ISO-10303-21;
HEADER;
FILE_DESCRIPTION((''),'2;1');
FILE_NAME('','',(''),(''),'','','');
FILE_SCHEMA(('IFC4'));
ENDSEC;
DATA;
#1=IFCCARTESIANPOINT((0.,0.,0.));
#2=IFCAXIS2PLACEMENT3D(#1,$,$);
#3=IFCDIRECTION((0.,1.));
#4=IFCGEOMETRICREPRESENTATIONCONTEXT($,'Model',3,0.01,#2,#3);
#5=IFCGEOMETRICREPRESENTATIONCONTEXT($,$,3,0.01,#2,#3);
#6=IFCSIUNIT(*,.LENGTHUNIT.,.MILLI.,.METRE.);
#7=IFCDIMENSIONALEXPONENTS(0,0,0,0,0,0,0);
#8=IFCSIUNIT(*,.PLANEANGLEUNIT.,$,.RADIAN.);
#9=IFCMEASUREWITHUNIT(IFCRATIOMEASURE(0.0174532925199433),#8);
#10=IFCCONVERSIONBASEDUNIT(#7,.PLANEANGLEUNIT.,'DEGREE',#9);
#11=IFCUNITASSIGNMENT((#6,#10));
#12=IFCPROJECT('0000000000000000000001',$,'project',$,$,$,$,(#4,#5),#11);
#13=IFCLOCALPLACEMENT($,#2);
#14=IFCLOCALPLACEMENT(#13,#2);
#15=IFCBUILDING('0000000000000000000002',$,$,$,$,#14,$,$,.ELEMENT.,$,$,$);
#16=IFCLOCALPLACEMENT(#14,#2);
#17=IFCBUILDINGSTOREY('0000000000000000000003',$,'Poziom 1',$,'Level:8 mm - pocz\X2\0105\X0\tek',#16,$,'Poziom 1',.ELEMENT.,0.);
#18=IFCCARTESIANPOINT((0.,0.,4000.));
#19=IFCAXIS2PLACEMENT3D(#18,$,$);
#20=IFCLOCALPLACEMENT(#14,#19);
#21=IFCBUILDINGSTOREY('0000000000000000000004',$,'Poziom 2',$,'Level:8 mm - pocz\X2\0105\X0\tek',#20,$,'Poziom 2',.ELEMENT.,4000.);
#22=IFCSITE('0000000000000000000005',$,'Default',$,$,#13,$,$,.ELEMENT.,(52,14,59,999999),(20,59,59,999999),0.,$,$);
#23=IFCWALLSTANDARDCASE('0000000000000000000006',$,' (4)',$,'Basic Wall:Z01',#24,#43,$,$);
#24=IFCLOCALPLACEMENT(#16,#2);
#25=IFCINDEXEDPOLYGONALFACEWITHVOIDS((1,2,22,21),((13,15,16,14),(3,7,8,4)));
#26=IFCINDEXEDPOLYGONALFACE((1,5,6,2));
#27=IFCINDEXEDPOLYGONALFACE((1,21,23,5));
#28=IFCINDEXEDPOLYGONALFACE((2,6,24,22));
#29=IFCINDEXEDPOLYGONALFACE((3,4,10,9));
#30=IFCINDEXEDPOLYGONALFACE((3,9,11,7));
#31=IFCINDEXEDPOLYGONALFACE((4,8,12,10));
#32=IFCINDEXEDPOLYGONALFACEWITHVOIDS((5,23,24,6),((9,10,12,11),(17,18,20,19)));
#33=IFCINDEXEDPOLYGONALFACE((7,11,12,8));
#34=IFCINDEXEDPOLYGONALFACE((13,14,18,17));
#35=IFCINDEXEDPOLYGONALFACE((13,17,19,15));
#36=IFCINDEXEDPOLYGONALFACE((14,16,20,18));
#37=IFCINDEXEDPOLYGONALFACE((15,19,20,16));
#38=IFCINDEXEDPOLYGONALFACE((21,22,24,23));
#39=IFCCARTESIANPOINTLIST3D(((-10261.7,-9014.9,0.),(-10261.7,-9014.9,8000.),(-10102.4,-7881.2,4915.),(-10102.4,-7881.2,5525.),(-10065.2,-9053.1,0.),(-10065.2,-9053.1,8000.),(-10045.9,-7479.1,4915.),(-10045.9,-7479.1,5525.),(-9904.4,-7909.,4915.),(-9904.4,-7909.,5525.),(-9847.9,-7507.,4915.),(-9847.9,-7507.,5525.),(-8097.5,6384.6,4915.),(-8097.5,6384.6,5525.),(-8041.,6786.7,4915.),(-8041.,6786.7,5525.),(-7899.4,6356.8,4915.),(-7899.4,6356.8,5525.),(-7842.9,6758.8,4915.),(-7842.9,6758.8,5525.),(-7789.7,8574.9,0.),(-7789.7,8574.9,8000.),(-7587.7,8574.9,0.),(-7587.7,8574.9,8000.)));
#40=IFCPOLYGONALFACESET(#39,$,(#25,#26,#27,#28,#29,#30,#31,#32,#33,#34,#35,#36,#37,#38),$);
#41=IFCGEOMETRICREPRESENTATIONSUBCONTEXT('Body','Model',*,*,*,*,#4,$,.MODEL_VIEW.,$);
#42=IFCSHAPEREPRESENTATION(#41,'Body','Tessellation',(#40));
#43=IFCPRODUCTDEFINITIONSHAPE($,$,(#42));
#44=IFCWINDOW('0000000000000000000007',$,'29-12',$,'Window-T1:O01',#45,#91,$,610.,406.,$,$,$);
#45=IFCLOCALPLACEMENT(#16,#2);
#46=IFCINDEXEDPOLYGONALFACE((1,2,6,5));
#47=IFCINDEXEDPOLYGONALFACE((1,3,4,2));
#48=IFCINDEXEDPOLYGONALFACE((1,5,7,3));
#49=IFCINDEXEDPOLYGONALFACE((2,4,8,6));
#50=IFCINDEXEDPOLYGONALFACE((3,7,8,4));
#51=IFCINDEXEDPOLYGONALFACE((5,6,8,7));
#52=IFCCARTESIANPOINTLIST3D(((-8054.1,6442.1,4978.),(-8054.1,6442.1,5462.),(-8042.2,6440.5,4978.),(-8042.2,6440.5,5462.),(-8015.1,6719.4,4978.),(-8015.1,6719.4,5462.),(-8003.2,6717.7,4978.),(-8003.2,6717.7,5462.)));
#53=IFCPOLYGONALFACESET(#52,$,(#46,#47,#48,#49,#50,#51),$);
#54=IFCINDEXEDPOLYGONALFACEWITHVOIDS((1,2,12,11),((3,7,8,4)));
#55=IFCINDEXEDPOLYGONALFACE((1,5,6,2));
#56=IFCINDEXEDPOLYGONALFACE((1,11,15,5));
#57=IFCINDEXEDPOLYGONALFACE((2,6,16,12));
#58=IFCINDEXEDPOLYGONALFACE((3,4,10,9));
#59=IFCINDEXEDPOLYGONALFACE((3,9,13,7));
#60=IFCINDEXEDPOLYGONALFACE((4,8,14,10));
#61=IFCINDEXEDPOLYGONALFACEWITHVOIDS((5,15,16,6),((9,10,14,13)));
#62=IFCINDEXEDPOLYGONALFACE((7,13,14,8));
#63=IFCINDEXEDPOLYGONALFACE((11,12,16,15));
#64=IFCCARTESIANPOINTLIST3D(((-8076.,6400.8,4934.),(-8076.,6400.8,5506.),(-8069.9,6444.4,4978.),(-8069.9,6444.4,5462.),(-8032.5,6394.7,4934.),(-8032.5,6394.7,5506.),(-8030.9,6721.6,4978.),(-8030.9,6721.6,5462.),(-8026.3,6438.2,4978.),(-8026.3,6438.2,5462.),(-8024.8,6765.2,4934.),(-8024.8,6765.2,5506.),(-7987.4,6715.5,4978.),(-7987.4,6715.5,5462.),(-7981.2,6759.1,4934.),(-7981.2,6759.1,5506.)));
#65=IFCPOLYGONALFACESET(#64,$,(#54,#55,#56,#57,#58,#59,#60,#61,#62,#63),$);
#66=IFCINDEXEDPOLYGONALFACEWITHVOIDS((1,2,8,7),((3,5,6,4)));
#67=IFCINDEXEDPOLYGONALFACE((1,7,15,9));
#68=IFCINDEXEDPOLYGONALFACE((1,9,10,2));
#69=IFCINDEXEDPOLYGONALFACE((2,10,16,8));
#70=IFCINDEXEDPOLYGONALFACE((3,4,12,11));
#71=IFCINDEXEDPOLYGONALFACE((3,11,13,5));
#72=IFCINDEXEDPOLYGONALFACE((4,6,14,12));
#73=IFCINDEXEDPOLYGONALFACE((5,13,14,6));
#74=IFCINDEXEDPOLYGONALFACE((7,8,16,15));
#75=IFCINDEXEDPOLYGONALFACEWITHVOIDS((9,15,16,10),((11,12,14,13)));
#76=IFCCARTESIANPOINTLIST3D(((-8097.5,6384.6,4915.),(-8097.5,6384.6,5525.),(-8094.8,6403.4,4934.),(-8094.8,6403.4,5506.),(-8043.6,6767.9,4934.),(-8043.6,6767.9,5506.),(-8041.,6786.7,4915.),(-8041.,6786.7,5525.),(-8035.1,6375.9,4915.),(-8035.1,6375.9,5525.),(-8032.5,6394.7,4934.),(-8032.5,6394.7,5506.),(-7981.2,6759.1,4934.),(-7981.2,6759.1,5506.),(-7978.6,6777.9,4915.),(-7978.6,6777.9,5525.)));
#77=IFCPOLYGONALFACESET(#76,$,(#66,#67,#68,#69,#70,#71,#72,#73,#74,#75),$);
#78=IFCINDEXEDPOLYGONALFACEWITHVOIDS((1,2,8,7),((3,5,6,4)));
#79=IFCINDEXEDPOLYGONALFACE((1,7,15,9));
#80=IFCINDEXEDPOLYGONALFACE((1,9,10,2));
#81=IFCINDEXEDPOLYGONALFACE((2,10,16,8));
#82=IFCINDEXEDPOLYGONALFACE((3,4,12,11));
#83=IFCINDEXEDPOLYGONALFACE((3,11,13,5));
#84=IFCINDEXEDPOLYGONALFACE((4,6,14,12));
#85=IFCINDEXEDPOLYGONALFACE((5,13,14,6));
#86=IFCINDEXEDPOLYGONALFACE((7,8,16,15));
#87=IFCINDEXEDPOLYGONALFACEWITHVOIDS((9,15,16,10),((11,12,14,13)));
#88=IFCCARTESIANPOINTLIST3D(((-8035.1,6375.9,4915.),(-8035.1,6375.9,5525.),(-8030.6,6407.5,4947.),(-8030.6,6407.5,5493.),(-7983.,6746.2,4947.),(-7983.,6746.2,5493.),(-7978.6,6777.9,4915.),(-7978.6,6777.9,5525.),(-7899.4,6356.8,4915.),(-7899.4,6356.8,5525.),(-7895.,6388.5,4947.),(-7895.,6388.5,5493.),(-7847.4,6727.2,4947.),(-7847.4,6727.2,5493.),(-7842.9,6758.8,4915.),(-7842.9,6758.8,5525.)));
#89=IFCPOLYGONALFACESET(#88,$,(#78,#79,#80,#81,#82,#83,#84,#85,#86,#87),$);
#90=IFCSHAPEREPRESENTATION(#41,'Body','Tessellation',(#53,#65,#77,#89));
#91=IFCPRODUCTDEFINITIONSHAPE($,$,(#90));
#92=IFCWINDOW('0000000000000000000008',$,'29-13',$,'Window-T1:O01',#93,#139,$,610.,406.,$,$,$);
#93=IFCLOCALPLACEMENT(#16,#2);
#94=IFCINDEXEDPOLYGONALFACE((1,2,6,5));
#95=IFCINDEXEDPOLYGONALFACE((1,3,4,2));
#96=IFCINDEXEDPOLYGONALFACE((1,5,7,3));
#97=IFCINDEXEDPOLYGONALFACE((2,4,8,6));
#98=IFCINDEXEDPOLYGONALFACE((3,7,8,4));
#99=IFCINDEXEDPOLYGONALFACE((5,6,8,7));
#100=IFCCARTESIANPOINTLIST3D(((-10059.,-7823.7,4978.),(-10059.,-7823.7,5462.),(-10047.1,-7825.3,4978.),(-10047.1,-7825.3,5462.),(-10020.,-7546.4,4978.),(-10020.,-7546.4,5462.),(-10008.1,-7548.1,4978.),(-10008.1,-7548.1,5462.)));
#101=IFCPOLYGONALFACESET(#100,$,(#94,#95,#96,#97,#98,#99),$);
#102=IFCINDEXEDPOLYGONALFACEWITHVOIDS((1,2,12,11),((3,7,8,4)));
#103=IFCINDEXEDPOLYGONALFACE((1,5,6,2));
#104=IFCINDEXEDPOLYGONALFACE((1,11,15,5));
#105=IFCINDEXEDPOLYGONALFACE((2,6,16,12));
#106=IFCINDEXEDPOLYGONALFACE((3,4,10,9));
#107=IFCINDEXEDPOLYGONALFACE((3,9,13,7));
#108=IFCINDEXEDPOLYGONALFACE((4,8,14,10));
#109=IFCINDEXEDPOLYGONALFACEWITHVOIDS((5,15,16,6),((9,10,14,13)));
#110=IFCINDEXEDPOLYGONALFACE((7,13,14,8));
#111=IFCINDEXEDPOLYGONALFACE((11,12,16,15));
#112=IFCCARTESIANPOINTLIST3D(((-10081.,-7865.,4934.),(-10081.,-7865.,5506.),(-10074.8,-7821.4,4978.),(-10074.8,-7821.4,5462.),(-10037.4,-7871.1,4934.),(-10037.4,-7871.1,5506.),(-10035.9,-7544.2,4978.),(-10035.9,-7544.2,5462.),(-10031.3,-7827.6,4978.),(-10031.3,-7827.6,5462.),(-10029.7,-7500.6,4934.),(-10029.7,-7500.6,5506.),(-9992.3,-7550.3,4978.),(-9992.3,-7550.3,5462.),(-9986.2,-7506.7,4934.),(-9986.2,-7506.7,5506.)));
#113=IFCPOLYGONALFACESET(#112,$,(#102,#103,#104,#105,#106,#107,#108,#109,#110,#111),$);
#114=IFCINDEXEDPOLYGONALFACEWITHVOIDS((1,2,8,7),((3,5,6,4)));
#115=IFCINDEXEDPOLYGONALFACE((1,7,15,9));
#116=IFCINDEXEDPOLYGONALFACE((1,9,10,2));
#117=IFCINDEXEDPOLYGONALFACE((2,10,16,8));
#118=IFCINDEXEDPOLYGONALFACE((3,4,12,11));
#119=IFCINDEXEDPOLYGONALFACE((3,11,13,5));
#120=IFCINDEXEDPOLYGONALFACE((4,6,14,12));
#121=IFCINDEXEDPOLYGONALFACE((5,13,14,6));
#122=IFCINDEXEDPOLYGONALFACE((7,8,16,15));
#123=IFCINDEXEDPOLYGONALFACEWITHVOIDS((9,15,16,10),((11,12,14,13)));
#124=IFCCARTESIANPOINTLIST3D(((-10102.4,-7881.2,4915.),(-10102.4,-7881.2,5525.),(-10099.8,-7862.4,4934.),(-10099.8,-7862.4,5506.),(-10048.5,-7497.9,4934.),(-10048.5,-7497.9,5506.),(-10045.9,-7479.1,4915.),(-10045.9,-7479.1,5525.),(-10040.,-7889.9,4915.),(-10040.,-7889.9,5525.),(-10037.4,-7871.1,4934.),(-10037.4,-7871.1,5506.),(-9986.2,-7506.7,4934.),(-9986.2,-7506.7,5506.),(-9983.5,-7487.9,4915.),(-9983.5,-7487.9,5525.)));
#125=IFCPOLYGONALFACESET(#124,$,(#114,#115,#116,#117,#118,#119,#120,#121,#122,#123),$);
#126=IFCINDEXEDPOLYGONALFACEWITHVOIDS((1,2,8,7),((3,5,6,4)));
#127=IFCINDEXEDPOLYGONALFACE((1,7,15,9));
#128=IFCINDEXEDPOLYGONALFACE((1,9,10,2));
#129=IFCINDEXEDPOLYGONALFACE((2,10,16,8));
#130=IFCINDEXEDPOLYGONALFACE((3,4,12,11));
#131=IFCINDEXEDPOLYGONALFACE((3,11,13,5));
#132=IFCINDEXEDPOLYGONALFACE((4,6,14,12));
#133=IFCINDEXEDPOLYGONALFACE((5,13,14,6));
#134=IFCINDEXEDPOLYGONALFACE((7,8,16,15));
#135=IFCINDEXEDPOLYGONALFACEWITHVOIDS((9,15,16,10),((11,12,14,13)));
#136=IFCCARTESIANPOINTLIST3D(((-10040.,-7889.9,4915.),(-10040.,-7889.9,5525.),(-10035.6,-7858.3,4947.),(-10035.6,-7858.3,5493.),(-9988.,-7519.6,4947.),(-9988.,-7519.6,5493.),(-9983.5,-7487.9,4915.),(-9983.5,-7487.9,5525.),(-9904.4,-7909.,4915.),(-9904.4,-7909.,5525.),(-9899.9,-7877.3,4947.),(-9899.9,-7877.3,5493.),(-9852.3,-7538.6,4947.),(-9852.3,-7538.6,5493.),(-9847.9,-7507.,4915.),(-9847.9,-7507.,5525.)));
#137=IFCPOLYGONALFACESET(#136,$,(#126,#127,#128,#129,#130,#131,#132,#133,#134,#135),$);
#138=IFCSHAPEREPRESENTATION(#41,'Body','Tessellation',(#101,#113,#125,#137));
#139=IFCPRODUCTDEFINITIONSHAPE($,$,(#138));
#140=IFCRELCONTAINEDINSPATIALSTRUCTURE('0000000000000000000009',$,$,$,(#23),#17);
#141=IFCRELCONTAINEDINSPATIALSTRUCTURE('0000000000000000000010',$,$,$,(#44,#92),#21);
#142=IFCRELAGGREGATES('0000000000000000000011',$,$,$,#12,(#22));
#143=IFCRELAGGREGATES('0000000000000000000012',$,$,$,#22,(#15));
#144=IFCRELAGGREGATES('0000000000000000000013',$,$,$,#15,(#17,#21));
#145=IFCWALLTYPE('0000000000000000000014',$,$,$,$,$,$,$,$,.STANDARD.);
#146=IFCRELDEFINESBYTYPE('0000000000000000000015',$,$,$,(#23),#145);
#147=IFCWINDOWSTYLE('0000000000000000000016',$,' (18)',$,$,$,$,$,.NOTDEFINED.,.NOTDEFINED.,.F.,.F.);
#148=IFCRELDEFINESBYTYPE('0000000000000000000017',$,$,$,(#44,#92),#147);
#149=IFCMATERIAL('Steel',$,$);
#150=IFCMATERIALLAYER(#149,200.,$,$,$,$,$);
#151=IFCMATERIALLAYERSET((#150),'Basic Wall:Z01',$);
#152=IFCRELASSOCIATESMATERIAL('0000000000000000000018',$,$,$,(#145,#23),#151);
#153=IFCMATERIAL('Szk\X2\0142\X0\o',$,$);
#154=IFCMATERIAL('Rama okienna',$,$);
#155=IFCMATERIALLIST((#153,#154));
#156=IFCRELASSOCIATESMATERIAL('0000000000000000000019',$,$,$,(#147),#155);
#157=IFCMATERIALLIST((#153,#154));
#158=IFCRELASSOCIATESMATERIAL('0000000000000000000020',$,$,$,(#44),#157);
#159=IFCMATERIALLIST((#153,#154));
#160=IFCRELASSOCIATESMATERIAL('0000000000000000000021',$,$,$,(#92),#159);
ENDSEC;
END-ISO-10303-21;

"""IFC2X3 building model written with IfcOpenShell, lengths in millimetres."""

from ifc_helpers import new_model, entity, si_unit, converted_unit, direction, frame, frame_2d, origin, place, context, subcontext, project, spatial, polyline, rectangle, outline, extrude, source, transform, mapped, material, material_list, layer, layer_set, layer_usage, type_object, type_shapes, element, fill, save


model = new_model("IFC2X3")

# Units and contexts
model_context = context("Model", 3, precision=0.01, world=origin(), true_north=direction((0.0, 1.0)))
context_of_model = context(None, 3, precision=0.01, world=origin(), true_north=direction((0.0, 1.0)))
body_context = subcontext(model_context, "Body", "Model", "MODEL_VIEW")
ifc_project = project(units=[si_unit("LENGTHUNIT", "METRE", prefix="MILLI"), converted_unit("PLANEANGLEUNIT", "DEGREE", entity("IfcRatioMeasure", 0.0174532925199433), si_unit("PLANEANGLEUNIT", "RADIAN"), dimensions=[0, 0, 0, 0, 0, 0, 0])], contexts=[model_context, context_of_model])

# Site, building, storey
site_placement = place(None, origin())
site = spatial("IfcSite", under=ifc_project, at=site_placement, Name="Default", CompositionType="ELEMENT", RefLatitude=(52, 14, 59, 999999), RefLongitude=(20, 59, 59, 999999), RefElevation=0.0)
building_placement = place(site_placement, origin())
building = spatial("IfcBuilding", under=site, at=building_placement, CompositionType="ELEMENT")
storey_1_placement = place(building_placement, origin())
storey_1 = spatial("IfcBuildingStorey", under=building, at=storey_1_placement, Name="Poziom 1", ObjectType="Level:8 mm - początek", LongName="Poziom 1", CompositionType="ELEMENT", Elevation=0.0)

# Wall, openings
ifc_material_1 = material(Name="Steel")
ifc_layer_1 = layer(ifc_material_1, 200.0)
ifc_layer_set_1 = layer_set([ifc_layer_1], Name="Basic Wall:Z01")
ifc_layer_usage_1 = layer_usage(ifc_layer_set_1, "AXIS2", "NEGATIVE", 100.0)
wall_type_1 = type_object("IfcWallType", PredefinedType="STANDARD", material=ifc_layer_set_1)
wall_1_placement = place(storey_1_placement, frame((-7686.7, 8588.8, 0.0), z_axis=(0.0, 0.0, 1.0), x_axis=(-0.139173, -0.990268, 0.0)))
wall_1 = element("IfcWallStandardCase", 1, at=wall_1_placement, inside=storey_1, type_object=wall_type_1, material=ifc_layer_usage_1, Name=" (4)", ObjectType="Basic Wall:Z01", context=body_context, shape_type="SweptSolid", body=[
    extrude(outline(polyline([(17790.8, -100.0), (17801.2, 100.0), (17300.6, 100.0), (504.9, 100.0), (0.0, 100.0), (28.1, -100.0), (17790.8, -100.0)])), origin(), (0.0, 0.0, 1.0), 8000.0),
])
opening_1_placement = place(wall_1_placement, frame((2239.9, 100.0, 4915.0)))
opening_1 = element("IfcOpeningElement", 2, at=opening_1_placement, cuts=wall_1, ObjectType="Opening", context=body_context, shape_type="SweptSolid", body=[
    extrude(rectangle(XDim=610.0, YDim=406.0, at=frame_2d((305.0, 203.0), x_axis=(1.0, 0.0))), frame((0.0, 0.0, 0.0), z_axis=(0.0, -1.0, 0.0), x_axis=(0.0, 0.0, 1.0)), (0.0, 0.0, 1.0), 200.0),
])
opening_2_placement = place(wall_1_placement, frame((16645.9, 100.0, 4915.0)))
opening_2 = element("IfcOpeningElement", 3, at=opening_2_placement, cuts=wall_1, ObjectType="Opening", context=body_context, shape_type="SweptSolid", body=[
    extrude(rectangle(XDim=610.0, YDim=406.0, at=frame_2d((305.0, 203.0), x_axis=(1.0, 0.0))), frame((0.0, 0.0, 0.0), z_axis=(0.0, -1.0, 0.0), x_axis=(0.0, 0.0, 1.0)), (0.0, 0.0, 1.0), 200.0),
])

# Shared definitions
storey_2_placement = place(building_placement, frame((0.0, 0.0, 4000.0)))
storey_2 = spatial("IfcBuildingStorey", under=building, at=storey_2_placement, Name="Poziom 2", ObjectType="Level:8 mm - początek", LongName="Poziom 2", CompositionType="ELEMENT", Elevation=4000.0)

# Windows
ifc_material_2 = material(Name="Szkło")
ifc_material_3 = material(Name="Rama okienna")
ifc_material_list_1 = material_list([ifc_material_2, ifc_material_3])
ifc_material_list_2 = material_list([ifc_material_2, ifc_material_3])
window_style_1 = type_object("IfcWindowStyle", Name=" (18)", ConstructionType="NOTDEFINED", OperationType="NOTDEFINED", ParameterTakesPrecedence=False, Sizeable=False, material=ifc_material_list_2)
shared_shape_1 = source(origin(), body_context, "Body", "SweptSolid", [
    extrude(rectangle(XDim=12.0, YDim=280.0, at=frame_2d((0.0, 0.0), x_axis=(1.0, 0.0))), frame((203.0, 159.0, 63.0), z_axis=(0.0, 0.0, 1.0), x_axis=(0.0, -1.0, 0.0)), (0.0, 0.0, 1.0), 484.0),
    extrude(outline(polyline([(-184.0, -286.0), (184.0, -286.0), (184.0, 286.0), (-184.0, 286.0), (-184.0, -286.0)]), holes=[polyline([(-140.0, -242.0), (-140.0, 242.0), (140.0, 242.0), (140.0, -242.0), (-140.0, -242.0)])]), frame((203.0, 137.0, 305.0), z_axis=(0.0, 1.0, 0.0), x_axis=(1.0, 0.0, 0.0)), (0.0, 0.0, 1.0), 44.0),
    extrude(outline(polyline([(-203.0, -305.0), (203.0, -305.0), (203.0, 305.0), (-203.0, 305.0), (-203.0, -305.0)]), holes=[polyline([(-184.0, -286.0), (-184.0, 286.0), (184.0, 286.0), (184.0, -286.0), (-184.0, -286.0)])]), frame((203.0, 137.0, 305.0), z_axis=(0.0, 1.0, 0.0), x_axis=(1.0, 0.0, 0.0)), (0.0, 0.0, 1.0), 63.0),
    extrude(outline(polyline([(-203.0, -305.0), (203.0, -305.0), (203.0, 305.0), (-203.0, 305.0), (-203.0, -305.0)]), holes=[polyline([(-171.0, -273.0), (-171.0, 273.0), (171.0, 273.0), (171.0, -273.0), (-171.0, -273.0)])]), frame((203.0, 0.0, 305.0), z_axis=(0.0, 1.0, 0.0), x_axis=(1.0, 0.0, 0.0)), (0.0, 0.0, 1.0), 137.0),
])
type_shapes(window_style_1, [shared_shape_1])
window_1_placement = place(opening_1_placement, frame((0.0, 0.0, 0.0), z_axis=(0.0, 0.0, 1.0), x_axis=(-1.0, 0.0, 0.0)))
window_1 = element("IfcWindow", 4, at=window_1_placement, inside=storey_2, type_object=window_style_1, material=ifc_material_list_1, Name="29-12", ObjectType="Window-T1:O01", OverallHeight=610.0, OverallWidth=406.0, context=body_context, shape_type="MappedRepresentation", body=[
    mapped(shared_shape_1, transform((0.0, 0.0, 0.0), scale=1.0)),
])
fill(opening_1, window_1)
ifc_material_list_3 = material_list([ifc_material_2, ifc_material_3])
window_2_placement = place(opening_2_placement, frame((0.0, 0.0, 0.0), z_axis=(0.0, 0.0, 1.0), x_axis=(-1.0, 0.0, 0.0)))
window_2 = element("IfcWindow", 5, at=window_2_placement, inside=storey_2, type_object=window_style_1, material=ifc_material_list_3, Name="29-13", ObjectType="Window-T1:O01", OverallHeight=610.0, OverallWidth=406.0, context=body_context, shape_type="MappedRepresentation", body=[
    mapped(shared_shape_1, transform((0.0, 0.0, 0.0), scale=1.0)),
])
fill(opening_2, window_2)

save(model, "model.ifc")
